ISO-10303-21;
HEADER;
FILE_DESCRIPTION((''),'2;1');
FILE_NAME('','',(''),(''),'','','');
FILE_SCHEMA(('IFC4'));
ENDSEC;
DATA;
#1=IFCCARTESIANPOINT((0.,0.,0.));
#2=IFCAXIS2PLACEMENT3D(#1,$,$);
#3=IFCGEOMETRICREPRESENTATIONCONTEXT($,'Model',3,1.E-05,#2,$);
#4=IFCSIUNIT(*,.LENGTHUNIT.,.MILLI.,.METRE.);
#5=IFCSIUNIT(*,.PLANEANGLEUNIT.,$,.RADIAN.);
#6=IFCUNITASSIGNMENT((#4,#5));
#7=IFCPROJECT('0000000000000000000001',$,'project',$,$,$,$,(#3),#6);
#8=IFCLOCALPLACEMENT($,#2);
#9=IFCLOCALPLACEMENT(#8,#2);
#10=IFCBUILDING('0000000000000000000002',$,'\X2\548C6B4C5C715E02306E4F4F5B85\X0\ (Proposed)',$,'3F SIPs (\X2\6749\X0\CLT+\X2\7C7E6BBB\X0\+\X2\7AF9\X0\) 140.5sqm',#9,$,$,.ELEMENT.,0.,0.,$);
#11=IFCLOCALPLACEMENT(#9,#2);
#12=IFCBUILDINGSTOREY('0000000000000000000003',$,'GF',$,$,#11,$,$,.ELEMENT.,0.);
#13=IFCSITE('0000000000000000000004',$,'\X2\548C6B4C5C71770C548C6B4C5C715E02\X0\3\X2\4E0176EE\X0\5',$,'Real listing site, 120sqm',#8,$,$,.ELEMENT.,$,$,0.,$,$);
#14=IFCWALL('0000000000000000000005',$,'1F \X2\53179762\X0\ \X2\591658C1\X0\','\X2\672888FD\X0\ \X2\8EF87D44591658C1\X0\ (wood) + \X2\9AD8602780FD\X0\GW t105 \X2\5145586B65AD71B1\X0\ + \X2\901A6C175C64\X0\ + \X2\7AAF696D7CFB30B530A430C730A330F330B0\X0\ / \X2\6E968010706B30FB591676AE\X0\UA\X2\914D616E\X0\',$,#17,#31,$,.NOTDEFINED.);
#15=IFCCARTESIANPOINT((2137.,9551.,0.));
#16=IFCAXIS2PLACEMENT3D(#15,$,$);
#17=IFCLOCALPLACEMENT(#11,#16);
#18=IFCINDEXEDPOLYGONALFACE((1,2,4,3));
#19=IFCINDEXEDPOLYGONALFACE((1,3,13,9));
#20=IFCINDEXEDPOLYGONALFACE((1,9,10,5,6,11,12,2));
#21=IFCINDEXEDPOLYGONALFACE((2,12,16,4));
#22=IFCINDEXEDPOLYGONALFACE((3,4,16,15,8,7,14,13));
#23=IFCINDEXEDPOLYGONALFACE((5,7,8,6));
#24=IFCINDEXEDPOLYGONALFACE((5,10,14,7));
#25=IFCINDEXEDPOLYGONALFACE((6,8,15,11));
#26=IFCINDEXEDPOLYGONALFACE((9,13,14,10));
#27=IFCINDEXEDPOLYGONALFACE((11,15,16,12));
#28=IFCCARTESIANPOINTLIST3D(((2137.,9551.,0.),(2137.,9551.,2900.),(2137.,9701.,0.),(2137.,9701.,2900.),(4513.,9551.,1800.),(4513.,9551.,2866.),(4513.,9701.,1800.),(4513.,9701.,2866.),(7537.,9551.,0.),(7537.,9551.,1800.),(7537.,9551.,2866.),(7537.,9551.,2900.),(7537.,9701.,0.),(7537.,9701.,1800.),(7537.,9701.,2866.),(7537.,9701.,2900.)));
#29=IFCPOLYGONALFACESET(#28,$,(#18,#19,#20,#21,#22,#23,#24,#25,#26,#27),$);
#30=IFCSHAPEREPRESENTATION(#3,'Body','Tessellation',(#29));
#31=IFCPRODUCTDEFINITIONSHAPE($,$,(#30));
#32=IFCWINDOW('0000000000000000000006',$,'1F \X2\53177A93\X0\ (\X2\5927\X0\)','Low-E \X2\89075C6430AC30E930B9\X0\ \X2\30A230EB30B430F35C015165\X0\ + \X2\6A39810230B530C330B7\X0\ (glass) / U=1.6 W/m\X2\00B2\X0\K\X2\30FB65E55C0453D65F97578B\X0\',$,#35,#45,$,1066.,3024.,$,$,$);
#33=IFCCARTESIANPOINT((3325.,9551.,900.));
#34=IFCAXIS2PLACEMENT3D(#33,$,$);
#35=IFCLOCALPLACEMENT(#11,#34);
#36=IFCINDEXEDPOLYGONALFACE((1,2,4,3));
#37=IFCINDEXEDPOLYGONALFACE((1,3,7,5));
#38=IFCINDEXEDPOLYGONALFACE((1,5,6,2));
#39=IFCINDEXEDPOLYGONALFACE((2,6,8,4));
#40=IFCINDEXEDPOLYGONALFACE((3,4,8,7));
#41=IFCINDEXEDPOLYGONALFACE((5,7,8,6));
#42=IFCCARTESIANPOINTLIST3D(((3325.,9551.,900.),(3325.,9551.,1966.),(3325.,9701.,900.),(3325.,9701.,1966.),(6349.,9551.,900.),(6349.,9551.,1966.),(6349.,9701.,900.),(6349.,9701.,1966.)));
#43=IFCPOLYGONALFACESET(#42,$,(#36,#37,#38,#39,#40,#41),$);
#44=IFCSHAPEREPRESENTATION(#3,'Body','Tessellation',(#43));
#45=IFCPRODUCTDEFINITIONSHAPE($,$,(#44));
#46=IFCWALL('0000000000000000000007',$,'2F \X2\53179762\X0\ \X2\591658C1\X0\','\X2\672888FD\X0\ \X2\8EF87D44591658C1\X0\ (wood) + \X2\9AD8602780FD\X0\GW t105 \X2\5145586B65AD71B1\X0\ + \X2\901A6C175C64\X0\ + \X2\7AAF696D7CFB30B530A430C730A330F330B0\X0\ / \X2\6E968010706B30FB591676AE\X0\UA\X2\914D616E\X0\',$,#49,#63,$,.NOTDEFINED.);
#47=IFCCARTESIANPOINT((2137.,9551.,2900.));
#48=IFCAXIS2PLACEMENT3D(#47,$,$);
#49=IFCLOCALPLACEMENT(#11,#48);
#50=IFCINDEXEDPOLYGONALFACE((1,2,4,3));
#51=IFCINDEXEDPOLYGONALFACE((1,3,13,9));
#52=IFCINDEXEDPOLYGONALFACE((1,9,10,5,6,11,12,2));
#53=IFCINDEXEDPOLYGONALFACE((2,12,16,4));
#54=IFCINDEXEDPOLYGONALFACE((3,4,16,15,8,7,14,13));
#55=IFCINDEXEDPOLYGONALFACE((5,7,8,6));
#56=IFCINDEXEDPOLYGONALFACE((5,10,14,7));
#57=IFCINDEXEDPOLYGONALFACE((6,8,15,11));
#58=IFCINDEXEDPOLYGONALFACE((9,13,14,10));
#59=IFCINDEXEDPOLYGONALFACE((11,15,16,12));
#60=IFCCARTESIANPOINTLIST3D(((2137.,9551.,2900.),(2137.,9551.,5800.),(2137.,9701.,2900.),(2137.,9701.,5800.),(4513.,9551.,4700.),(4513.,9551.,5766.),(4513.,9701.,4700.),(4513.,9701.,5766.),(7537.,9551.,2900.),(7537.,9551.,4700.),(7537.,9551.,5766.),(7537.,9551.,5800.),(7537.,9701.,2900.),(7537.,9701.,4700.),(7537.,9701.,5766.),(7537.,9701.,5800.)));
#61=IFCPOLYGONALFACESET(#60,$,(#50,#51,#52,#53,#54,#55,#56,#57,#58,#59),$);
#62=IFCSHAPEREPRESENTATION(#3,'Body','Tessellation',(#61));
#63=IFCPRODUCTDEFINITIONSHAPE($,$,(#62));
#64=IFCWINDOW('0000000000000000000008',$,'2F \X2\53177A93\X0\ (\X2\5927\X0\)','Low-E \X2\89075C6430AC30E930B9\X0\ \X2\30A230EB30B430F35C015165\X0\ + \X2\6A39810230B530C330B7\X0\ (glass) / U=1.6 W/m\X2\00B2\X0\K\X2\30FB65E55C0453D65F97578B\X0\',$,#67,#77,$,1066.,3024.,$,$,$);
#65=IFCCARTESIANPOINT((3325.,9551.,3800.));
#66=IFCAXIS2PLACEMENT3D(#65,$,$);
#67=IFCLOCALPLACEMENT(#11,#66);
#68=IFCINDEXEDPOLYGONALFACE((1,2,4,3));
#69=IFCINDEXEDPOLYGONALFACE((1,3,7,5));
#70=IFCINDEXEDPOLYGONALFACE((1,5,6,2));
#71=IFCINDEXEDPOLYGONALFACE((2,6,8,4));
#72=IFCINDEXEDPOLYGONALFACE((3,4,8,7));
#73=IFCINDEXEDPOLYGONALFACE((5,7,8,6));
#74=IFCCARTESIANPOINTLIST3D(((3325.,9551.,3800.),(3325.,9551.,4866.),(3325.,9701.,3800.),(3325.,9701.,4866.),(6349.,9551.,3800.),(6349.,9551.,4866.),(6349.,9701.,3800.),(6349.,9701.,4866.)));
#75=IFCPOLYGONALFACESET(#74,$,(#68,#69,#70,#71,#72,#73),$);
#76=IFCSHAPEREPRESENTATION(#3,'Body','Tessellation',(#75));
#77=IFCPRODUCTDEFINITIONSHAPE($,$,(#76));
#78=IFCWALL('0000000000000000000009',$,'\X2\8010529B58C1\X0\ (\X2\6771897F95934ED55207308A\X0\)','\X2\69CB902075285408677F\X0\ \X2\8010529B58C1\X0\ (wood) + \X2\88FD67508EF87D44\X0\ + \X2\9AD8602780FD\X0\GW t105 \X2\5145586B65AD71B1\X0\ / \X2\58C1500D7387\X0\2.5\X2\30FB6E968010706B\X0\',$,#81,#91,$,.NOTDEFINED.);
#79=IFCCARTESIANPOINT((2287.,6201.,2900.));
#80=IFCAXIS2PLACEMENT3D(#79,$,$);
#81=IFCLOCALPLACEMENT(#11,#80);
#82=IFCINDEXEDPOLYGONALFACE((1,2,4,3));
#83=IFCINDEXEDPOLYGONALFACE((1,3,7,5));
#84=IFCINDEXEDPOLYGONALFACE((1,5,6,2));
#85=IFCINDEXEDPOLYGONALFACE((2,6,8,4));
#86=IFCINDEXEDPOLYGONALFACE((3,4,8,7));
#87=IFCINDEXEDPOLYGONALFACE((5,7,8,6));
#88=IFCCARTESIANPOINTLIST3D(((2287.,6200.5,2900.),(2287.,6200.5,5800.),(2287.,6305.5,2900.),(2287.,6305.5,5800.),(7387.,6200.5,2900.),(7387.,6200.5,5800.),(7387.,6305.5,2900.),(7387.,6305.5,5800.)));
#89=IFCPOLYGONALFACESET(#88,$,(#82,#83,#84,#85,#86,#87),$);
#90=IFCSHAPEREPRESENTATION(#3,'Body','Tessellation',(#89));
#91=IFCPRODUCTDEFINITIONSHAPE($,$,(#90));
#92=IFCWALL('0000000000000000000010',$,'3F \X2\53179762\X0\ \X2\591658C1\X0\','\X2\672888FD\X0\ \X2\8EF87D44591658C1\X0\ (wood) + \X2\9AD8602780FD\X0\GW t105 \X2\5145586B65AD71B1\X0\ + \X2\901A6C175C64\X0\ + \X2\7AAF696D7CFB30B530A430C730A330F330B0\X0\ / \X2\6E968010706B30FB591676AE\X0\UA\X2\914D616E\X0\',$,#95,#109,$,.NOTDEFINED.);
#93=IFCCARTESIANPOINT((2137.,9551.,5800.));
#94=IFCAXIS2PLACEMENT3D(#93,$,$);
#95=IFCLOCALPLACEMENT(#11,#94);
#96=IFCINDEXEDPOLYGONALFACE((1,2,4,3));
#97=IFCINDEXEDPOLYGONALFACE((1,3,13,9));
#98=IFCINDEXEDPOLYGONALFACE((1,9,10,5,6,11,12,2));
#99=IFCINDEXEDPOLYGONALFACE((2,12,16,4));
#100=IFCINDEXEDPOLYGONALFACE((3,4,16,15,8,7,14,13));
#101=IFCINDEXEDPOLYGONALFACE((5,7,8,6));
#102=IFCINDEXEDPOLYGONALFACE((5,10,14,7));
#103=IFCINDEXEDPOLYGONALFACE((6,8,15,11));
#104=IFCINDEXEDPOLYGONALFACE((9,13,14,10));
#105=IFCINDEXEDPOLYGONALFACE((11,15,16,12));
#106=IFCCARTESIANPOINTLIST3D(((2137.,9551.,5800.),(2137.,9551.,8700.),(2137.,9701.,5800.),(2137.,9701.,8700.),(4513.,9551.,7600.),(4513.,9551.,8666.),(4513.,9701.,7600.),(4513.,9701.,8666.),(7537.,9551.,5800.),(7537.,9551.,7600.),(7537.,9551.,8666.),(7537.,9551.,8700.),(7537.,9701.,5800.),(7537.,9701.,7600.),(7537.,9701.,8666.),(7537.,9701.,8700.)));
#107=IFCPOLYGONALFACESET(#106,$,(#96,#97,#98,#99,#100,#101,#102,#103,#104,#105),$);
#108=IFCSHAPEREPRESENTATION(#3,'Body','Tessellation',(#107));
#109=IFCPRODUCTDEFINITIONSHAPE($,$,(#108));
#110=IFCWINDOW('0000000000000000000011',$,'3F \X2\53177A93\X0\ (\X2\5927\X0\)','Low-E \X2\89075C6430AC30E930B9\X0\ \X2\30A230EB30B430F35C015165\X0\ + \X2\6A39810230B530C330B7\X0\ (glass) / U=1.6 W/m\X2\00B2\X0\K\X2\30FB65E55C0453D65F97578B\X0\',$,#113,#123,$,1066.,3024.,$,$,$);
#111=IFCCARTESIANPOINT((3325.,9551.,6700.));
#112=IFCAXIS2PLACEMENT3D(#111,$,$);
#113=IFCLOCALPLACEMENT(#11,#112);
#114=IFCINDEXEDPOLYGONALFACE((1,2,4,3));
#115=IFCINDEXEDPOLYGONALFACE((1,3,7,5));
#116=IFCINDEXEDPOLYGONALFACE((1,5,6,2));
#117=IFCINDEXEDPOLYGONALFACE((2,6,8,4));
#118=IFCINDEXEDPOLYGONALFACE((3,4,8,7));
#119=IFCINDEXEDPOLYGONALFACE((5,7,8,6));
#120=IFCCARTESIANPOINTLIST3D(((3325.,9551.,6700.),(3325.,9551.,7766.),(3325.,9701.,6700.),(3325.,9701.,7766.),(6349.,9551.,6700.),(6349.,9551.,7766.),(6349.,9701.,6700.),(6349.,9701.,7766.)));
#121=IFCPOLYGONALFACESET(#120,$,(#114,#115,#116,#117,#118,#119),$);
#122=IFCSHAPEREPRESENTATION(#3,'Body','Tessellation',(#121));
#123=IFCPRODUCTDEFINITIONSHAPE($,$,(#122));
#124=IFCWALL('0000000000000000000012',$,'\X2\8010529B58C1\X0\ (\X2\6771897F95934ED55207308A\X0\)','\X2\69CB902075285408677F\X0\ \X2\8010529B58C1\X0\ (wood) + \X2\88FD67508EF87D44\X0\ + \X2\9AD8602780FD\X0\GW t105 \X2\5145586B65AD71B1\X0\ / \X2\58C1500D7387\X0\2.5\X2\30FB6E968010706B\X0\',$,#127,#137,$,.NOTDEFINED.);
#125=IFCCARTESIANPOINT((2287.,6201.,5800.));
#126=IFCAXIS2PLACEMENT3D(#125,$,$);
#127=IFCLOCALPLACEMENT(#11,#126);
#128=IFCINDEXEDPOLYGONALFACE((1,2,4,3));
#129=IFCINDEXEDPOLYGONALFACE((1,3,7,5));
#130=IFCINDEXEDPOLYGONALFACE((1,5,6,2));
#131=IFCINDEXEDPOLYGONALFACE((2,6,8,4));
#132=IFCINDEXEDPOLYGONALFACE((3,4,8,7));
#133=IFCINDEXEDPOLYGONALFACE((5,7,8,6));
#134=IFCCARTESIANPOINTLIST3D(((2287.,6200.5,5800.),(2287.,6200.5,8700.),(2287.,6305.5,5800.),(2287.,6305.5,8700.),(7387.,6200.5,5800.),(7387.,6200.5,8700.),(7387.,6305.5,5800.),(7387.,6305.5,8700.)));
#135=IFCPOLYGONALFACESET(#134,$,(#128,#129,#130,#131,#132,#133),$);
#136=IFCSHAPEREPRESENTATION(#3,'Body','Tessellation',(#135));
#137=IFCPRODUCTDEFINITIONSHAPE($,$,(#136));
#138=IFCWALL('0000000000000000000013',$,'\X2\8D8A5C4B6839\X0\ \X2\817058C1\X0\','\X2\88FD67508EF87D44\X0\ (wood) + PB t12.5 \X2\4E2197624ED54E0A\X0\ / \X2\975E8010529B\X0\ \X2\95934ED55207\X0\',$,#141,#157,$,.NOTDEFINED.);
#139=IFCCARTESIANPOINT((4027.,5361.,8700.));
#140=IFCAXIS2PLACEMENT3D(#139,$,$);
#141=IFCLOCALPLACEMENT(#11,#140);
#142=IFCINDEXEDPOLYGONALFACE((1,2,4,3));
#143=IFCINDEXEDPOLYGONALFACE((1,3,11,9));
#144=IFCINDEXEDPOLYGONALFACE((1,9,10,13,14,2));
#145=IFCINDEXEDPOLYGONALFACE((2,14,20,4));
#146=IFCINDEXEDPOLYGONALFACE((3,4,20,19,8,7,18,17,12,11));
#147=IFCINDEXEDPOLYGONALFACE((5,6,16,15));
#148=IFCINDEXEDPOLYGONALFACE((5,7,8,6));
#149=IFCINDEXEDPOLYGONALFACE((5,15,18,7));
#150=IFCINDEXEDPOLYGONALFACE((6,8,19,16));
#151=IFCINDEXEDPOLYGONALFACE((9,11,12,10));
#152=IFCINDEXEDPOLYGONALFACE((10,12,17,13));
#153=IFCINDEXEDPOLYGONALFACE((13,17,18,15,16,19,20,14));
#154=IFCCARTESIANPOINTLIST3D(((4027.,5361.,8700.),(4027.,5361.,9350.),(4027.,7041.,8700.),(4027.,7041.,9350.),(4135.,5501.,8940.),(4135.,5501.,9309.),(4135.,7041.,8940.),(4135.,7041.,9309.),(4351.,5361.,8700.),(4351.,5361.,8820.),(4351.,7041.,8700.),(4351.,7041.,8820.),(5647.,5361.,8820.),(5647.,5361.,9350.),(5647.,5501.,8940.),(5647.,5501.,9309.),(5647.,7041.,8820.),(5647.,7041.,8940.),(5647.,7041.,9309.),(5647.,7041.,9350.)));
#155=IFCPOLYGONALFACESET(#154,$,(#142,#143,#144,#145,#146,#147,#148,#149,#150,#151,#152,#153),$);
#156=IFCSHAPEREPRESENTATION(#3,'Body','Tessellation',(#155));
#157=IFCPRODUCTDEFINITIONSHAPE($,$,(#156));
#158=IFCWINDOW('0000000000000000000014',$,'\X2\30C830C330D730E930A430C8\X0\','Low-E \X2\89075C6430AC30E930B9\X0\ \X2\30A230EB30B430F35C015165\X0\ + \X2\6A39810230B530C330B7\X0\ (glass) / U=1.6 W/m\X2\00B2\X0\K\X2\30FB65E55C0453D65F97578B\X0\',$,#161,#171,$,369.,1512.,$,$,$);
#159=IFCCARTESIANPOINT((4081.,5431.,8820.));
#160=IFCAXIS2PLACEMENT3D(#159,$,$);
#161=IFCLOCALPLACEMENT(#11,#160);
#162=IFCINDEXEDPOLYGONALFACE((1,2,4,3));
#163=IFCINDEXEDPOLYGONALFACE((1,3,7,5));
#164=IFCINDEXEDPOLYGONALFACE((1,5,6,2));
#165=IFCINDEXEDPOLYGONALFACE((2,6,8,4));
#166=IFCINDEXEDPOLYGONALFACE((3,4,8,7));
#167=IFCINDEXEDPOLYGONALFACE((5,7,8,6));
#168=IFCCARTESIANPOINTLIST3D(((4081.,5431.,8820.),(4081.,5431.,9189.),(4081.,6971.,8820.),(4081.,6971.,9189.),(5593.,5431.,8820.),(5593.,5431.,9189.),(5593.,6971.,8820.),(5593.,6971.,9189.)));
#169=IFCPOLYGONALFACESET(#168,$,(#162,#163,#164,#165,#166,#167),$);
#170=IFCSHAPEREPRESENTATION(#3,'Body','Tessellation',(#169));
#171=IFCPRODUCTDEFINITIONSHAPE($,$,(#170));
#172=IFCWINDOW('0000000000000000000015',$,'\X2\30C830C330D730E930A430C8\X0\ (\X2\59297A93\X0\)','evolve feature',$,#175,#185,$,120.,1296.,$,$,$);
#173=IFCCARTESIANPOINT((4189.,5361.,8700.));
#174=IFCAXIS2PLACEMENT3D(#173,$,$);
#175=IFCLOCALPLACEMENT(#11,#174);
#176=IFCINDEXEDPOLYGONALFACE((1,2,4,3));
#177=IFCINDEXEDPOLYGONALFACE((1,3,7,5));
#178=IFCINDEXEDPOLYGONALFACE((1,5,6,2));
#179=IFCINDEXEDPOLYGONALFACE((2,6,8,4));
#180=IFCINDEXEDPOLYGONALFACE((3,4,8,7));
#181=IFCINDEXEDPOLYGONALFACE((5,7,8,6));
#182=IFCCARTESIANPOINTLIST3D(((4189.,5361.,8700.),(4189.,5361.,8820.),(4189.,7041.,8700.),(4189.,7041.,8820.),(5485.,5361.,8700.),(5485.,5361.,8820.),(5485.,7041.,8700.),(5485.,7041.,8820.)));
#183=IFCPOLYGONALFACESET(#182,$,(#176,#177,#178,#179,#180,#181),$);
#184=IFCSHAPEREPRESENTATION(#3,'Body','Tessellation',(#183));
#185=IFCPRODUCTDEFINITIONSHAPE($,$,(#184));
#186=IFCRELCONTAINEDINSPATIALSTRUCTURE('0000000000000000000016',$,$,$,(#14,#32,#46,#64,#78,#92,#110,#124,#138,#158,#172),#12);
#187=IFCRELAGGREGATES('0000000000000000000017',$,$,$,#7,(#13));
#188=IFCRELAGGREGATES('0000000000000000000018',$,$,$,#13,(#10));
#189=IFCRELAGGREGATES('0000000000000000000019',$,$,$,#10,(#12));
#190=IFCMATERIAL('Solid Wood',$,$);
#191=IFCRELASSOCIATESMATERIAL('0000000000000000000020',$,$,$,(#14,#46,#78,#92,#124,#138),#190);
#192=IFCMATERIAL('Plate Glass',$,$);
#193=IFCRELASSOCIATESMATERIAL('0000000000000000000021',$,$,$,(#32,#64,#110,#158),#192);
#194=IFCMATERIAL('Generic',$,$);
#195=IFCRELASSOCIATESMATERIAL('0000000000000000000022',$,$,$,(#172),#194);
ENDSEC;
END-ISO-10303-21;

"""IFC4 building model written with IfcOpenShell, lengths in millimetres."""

from ifc_helpers import new_model, si_unit, frame, frame_2d, origin, place, context, project, spatial, rectangle, extrude, material, element, fill, save


model = new_model("IFC4")

# Units and contexts
model_context = context("Model", 3, precision=1e-05, world=origin())
ifc_project = project(units=[si_unit("LENGTHUNIT", "METRE", prefix="MILLI"), si_unit("PLANEANGLEUNIT", "RADIAN")], contexts=[model_context])

# Site, building, storey
site_placement = place(None, origin())
site = spatial("IfcSite", under=ifc_project, at=site_placement, Name="和歌山県和歌山市3丁目5", ObjectType="Real listing site, 120sqm", CompositionType="ELEMENT", RefElevation=0.0)
building_placement = place(site_placement, origin())
building = spatial("IfcBuilding", under=site, at=building_placement, Name="和歌山市の住宅 (Proposed)", ObjectType="3F SIPs (杉CLT+籾殻+竹) 140.5sqm", CompositionType="ELEMENT", ElevationOfRefHeight=0.0, ElevationOfTerrain=0.0)
storey_placement = place(building_placement, origin())
storey = spatial("IfcBuildingStorey", under=building, at=storey_placement, Name="GF", CompositionType="ELEMENT", Elevation=0.0)

# Shared definitions
ifc_material_1 = material(Name="Generic")

# Wall, opening, window
ifc_material_2 = material(Name="Solid Wood")
wall_1_placement = place(storey_placement, frame((2137.0, 9551.0, 0.0)))
wall_1 = element("IfcWall", 1, at=wall_1_placement, inside=storey, material=ifc_material_2, Name="1F 北面 外壁", Description="木製 軸組外壁 (wood) + 高性能GW t105 充填断熱 + 通気層 + 窯業系サイディング / 準耐火・外皮UA配慮", PredefinedType="NOTDEFINED", context=model_context, shape_type="SweptSolid", body=[
    extrude(rectangle(XDim=5400.0, YDim=150.0, at=frame_2d((2700.0, 75.0))), frame((2137.0, 9551.0, 0.0)), (0.0, 0.0, 1.0), 2900.0),
])
opening_1_placement = place(storey_placement, frame((3325.0, 9551.0, 900.0)))
opening_1 = element("IfcOpeningElement", 2, at=opening_1_placement, cuts=wall_1, PredefinedType="NOTDEFINED", context=model_context, shape_type="SweptSolid", body=[
    extrude(rectangle(XDim=3024.0, YDim=150.0, at=frame_2d((1512.0, 75.0))), frame((3325.0, 9551.0, 900.0)), (0.0, 0.0, 1.0), 1066.0),
])
ifc_material_3 = material(Name="Plate Glass")
window_1_placement = place(storey_placement, frame((3325.0, 9551.0, 900.0)))
window_1 = element("IfcWindow", 3, at=window_1_placement, inside=storey, material=ifc_material_3, Name="1F 北窓 (大)", Description="Low-E 複層ガラス アルゴン封入 + 樹脂サッシ (glass) / U=1.6 W/m²K・日射取得型", OverallHeight=1066.0, OverallWidth=3024.0, context=model_context, shape_type="SweptSolid", body=[
    extrude(rectangle(XDim=3024.0, YDim=150.0, at=frame_2d((1512.0, 75.0))), frame((3325.0, 9551.0, 900.0)), (0.0, 0.0, 1.0), 1066.0),
])
fill(opening_1, window_1)

# Wall, opening, window
wall_2_placement = place(storey_placement, frame((2137.0, 9551.0, 2900.0)))
wall_2 = element("IfcWall", 4, at=wall_2_placement, inside=storey, material=ifc_material_2, Name="2F 北面 外壁", Description="木製 軸組外壁 (wood) + 高性能GW t105 充填断熱 + 通気層 + 窯業系サイディング / 準耐火・外皮UA配慮", PredefinedType="NOTDEFINED", context=model_context, shape_type="SweptSolid", body=[
    extrude(rectangle(XDim=5400.0, YDim=150.0, at=frame_2d((2700.0, 75.0))), frame((2137.0, 9551.0, 2900.0)), (0.0, 0.0, 1.0), 2900.0),
])
opening_2_placement = place(storey_placement, frame((3325.0, 9551.0, 3800.0)))
opening_2 = element("IfcOpeningElement", 5, at=opening_2_placement, cuts=wall_2, PredefinedType="NOTDEFINED", context=model_context, shape_type="SweptSolid", body=[
    extrude(rectangle(XDim=3024.0, YDim=150.0, at=frame_2d((1512.0, 75.0))), frame((3325.0, 9551.0, 3800.0)), (0.0, 0.0, 1.0), 1066.0),
])
window_2_placement = place(storey_placement, frame((3325.0, 9551.0, 3800.0)))
window_2 = element("IfcWindow", 6, at=window_2_placement, inside=storey, material=ifc_material_3, Name="2F 北窓 (大)", Description="Low-E 複層ガラス アルゴン封入 + 樹脂サッシ (glass) / U=1.6 W/m²K・日射取得型", OverallHeight=1066.0, OverallWidth=3024.0, context=model_context, shape_type="SweptSolid", body=[
    extrude(rectangle(XDim=3024.0, YDim=150.0, at=frame_2d((1512.0, 75.0))), frame((3325.0, 9551.0, 3800.0)), (0.0, 0.0, 1.0), 1066.0),
])
fill(opening_2, window_2)

# Wall
wall_3_placement = place(storey_placement, frame((2287.0, 6201.0, 2900.0)))
element("IfcWall", 7, at=wall_3_placement, inside=storey, material=ifc_material_2, Name="耐力壁 (東西間仕切り)", Description="構造用合板 耐力壁 (wood) + 製材軸組 + 高性能GW t105 充填断熱 / 壁倍率2.5・準耐火", PredefinedType="NOTDEFINED", context=model_context, shape_type="SweptSolid", body=[
    extrude(rectangle(XDim=5100.0, YDim=105.0, at=frame_2d((2550.0, 52.0))), frame((2287.0, 6201.0, 2900.0)), (0.0, 0.0, 1.0), 2900.0),
])

# Wall, opening, window
wall_4_placement = place(storey_placement, frame((2137.0, 9551.0, 5800.0)))
wall_4 = element("IfcWall", 8, at=wall_4_placement, inside=storey, material=ifc_material_2, Name="3F 北面 外壁", Description="木製 軸組外壁 (wood) + 高性能GW t105 充填断熱 + 通気層 + 窯業系サイディング / 準耐火・外皮UA配慮", PredefinedType="NOTDEFINED", context=model_context, shape_type="SweptSolid", body=[
    extrude(rectangle(XDim=5400.0, YDim=150.0, at=frame_2d((2700.0, 75.0))), frame((2137.0, 9551.0, 5800.0)), (0.0, 0.0, 1.0), 2900.0),
])
opening_3_placement = place(storey_placement, frame((3325.0, 9551.0, 6700.0)))
opening_3 = element("IfcOpeningElement", 9, at=opening_3_placement, cuts=wall_4, PredefinedType="NOTDEFINED", context=model_context, shape_type="SweptSolid", body=[
    extrude(rectangle(XDim=3024.0, YDim=150.0, at=frame_2d((1512.0, 75.0))), frame((3325.0, 9551.0, 6700.0)), (0.0, 0.0, 1.0), 1066.0),
])
window_3_placement = place(storey_placement, frame((3325.0, 9551.0, 6700.0)))
window_3 = element("IfcWindow", 10, at=window_3_placement, inside=storey, material=ifc_material_3, Name="3F 北窓 (大)", Description="Low-E 複層ガラス アルゴン封入 + 樹脂サッシ (glass) / U=1.6 W/m²K・日射取得型", OverallHeight=1066.0, OverallWidth=3024.0, context=model_context, shape_type="SweptSolid", body=[
    extrude(rectangle(XDim=3024.0, YDim=150.0, at=frame_2d((1512.0, 75.0))), frame((3325.0, 9551.0, 6700.0)), (0.0, 0.0, 1.0), 1066.0),
])
fill(opening_3, window_3)

# Wall
wall_5_placement = place(storey_placement, frame((2287.0, 6201.0, 5800.0)))
element("IfcWall", 11, at=wall_5_placement, inside=storey, material=ifc_material_2, Name="耐力壁 (東西間仕切り)", Description="構造用合板 耐力壁 (wood) + 製材軸組 + 高性能GW t105 充填断熱 / 壁倍率2.5・準耐火", PredefinedType="NOTDEFINED", context=model_context, shape_type="SweptSolid", body=[
    extrude(rectangle(XDim=5100.0, YDim=105.0, at=frame_2d((2550.0, 52.0))), frame((2287.0, 6201.0, 5800.0)), (0.0, 0.0, 1.0), 2900.0),
])

# Wall, openings, windows
wall_6_placement = place(storey_placement, frame((4027.0, 5361.0, 8700.0)))
wall_6 = element("IfcWall", 12, at=wall_6_placement, inside=storey, material=ifc_material_2, Name="越屋根 腰壁", Description="製材軸組 (wood) + PB t12.5 両面仕上 / 非耐力 間仕切", PredefinedType="NOTDEFINED", context=model_context, shape_type="SweptSolid", body=[
    extrude(rectangle(XDim=1620.0, YDim=1680.0, at=frame_2d((810.0, 840.0))), frame((4027.0, 5361.0, 8700.0)), (0.0, 0.0, 1.0), 650.0),
])
opening_4_placement = place(storey_placement, frame((4081.0, 5431.0, 8820.0)))
opening_4 = element("IfcOpeningElement", 13, at=opening_4_placement, cuts=wall_6, PredefinedType="NOTDEFINED", context=model_context, shape_type="SweptSolid", body=[
    extrude(rectangle(XDim=1512.0, YDim=1540.0, at=frame_2d((756.0, 770.0))), frame((4081.0, 5431.0, 8820.0)), (0.0, 0.0, 1.0), 369.0),
])
opening_5_placement = place(storey_placement, frame((4189.0, 5361.0, 8700.0)))
opening_5 = element("IfcOpeningElement", 14, at=opening_5_placement, cuts=wall_6, PredefinedType="NOTDEFINED", context=model_context, shape_type="SweptSolid", body=[
    extrude(rectangle(XDim=1296.0, YDim=1680.0, at=frame_2d((648.0, 840.0))), frame((4189.0, 5361.0, 8700.0)), (0.0, 0.0, 1.0), 120.0),
])
window_4_placement = place(storey_placement, frame((4081.0, 5431.0, 8820.0)))
window_4 = element("IfcWindow", 15, at=window_4_placement, inside=storey, material=ifc_material_3, Name="トップライト", Description="Low-E 複層ガラス アルゴン封入 + 樹脂サッシ (glass) / U=1.6 W/m²K・日射取得型", OverallHeight=369.0, OverallWidth=1512.0, context=model_context, shape_type="SweptSolid", body=[
    extrude(rectangle(XDim=1512.0, YDim=1540.0, at=frame_2d((756.0, 770.0))), frame((4081.0, 5431.0, 8820.0)), (0.0, 0.0, 1.0), 369.0),
])
fill(opening_4, window_4)
window_5_placement = place(storey_placement, frame((4189.0, 5361.0, 8700.0)))
window_5 = element("IfcWindow", 16, at=window_5_placement, inside=storey, material=ifc_material_1, Name="トップライト (天窓)", Description="evolve feature", OverallHeight=120.0, OverallWidth=1296.0, context=model_context, shape_type="SweptSolid", body=[
    extrude(rectangle(XDim=1296.0, YDim=1680.0, at=frame_2d((648.0, 840.0))), frame((4189.0, 5361.0, 8700.0)), (0.0, 0.0, 1.0), 120.0),
])
fill(opening_5, window_5)

save(model, "model.ifc")
